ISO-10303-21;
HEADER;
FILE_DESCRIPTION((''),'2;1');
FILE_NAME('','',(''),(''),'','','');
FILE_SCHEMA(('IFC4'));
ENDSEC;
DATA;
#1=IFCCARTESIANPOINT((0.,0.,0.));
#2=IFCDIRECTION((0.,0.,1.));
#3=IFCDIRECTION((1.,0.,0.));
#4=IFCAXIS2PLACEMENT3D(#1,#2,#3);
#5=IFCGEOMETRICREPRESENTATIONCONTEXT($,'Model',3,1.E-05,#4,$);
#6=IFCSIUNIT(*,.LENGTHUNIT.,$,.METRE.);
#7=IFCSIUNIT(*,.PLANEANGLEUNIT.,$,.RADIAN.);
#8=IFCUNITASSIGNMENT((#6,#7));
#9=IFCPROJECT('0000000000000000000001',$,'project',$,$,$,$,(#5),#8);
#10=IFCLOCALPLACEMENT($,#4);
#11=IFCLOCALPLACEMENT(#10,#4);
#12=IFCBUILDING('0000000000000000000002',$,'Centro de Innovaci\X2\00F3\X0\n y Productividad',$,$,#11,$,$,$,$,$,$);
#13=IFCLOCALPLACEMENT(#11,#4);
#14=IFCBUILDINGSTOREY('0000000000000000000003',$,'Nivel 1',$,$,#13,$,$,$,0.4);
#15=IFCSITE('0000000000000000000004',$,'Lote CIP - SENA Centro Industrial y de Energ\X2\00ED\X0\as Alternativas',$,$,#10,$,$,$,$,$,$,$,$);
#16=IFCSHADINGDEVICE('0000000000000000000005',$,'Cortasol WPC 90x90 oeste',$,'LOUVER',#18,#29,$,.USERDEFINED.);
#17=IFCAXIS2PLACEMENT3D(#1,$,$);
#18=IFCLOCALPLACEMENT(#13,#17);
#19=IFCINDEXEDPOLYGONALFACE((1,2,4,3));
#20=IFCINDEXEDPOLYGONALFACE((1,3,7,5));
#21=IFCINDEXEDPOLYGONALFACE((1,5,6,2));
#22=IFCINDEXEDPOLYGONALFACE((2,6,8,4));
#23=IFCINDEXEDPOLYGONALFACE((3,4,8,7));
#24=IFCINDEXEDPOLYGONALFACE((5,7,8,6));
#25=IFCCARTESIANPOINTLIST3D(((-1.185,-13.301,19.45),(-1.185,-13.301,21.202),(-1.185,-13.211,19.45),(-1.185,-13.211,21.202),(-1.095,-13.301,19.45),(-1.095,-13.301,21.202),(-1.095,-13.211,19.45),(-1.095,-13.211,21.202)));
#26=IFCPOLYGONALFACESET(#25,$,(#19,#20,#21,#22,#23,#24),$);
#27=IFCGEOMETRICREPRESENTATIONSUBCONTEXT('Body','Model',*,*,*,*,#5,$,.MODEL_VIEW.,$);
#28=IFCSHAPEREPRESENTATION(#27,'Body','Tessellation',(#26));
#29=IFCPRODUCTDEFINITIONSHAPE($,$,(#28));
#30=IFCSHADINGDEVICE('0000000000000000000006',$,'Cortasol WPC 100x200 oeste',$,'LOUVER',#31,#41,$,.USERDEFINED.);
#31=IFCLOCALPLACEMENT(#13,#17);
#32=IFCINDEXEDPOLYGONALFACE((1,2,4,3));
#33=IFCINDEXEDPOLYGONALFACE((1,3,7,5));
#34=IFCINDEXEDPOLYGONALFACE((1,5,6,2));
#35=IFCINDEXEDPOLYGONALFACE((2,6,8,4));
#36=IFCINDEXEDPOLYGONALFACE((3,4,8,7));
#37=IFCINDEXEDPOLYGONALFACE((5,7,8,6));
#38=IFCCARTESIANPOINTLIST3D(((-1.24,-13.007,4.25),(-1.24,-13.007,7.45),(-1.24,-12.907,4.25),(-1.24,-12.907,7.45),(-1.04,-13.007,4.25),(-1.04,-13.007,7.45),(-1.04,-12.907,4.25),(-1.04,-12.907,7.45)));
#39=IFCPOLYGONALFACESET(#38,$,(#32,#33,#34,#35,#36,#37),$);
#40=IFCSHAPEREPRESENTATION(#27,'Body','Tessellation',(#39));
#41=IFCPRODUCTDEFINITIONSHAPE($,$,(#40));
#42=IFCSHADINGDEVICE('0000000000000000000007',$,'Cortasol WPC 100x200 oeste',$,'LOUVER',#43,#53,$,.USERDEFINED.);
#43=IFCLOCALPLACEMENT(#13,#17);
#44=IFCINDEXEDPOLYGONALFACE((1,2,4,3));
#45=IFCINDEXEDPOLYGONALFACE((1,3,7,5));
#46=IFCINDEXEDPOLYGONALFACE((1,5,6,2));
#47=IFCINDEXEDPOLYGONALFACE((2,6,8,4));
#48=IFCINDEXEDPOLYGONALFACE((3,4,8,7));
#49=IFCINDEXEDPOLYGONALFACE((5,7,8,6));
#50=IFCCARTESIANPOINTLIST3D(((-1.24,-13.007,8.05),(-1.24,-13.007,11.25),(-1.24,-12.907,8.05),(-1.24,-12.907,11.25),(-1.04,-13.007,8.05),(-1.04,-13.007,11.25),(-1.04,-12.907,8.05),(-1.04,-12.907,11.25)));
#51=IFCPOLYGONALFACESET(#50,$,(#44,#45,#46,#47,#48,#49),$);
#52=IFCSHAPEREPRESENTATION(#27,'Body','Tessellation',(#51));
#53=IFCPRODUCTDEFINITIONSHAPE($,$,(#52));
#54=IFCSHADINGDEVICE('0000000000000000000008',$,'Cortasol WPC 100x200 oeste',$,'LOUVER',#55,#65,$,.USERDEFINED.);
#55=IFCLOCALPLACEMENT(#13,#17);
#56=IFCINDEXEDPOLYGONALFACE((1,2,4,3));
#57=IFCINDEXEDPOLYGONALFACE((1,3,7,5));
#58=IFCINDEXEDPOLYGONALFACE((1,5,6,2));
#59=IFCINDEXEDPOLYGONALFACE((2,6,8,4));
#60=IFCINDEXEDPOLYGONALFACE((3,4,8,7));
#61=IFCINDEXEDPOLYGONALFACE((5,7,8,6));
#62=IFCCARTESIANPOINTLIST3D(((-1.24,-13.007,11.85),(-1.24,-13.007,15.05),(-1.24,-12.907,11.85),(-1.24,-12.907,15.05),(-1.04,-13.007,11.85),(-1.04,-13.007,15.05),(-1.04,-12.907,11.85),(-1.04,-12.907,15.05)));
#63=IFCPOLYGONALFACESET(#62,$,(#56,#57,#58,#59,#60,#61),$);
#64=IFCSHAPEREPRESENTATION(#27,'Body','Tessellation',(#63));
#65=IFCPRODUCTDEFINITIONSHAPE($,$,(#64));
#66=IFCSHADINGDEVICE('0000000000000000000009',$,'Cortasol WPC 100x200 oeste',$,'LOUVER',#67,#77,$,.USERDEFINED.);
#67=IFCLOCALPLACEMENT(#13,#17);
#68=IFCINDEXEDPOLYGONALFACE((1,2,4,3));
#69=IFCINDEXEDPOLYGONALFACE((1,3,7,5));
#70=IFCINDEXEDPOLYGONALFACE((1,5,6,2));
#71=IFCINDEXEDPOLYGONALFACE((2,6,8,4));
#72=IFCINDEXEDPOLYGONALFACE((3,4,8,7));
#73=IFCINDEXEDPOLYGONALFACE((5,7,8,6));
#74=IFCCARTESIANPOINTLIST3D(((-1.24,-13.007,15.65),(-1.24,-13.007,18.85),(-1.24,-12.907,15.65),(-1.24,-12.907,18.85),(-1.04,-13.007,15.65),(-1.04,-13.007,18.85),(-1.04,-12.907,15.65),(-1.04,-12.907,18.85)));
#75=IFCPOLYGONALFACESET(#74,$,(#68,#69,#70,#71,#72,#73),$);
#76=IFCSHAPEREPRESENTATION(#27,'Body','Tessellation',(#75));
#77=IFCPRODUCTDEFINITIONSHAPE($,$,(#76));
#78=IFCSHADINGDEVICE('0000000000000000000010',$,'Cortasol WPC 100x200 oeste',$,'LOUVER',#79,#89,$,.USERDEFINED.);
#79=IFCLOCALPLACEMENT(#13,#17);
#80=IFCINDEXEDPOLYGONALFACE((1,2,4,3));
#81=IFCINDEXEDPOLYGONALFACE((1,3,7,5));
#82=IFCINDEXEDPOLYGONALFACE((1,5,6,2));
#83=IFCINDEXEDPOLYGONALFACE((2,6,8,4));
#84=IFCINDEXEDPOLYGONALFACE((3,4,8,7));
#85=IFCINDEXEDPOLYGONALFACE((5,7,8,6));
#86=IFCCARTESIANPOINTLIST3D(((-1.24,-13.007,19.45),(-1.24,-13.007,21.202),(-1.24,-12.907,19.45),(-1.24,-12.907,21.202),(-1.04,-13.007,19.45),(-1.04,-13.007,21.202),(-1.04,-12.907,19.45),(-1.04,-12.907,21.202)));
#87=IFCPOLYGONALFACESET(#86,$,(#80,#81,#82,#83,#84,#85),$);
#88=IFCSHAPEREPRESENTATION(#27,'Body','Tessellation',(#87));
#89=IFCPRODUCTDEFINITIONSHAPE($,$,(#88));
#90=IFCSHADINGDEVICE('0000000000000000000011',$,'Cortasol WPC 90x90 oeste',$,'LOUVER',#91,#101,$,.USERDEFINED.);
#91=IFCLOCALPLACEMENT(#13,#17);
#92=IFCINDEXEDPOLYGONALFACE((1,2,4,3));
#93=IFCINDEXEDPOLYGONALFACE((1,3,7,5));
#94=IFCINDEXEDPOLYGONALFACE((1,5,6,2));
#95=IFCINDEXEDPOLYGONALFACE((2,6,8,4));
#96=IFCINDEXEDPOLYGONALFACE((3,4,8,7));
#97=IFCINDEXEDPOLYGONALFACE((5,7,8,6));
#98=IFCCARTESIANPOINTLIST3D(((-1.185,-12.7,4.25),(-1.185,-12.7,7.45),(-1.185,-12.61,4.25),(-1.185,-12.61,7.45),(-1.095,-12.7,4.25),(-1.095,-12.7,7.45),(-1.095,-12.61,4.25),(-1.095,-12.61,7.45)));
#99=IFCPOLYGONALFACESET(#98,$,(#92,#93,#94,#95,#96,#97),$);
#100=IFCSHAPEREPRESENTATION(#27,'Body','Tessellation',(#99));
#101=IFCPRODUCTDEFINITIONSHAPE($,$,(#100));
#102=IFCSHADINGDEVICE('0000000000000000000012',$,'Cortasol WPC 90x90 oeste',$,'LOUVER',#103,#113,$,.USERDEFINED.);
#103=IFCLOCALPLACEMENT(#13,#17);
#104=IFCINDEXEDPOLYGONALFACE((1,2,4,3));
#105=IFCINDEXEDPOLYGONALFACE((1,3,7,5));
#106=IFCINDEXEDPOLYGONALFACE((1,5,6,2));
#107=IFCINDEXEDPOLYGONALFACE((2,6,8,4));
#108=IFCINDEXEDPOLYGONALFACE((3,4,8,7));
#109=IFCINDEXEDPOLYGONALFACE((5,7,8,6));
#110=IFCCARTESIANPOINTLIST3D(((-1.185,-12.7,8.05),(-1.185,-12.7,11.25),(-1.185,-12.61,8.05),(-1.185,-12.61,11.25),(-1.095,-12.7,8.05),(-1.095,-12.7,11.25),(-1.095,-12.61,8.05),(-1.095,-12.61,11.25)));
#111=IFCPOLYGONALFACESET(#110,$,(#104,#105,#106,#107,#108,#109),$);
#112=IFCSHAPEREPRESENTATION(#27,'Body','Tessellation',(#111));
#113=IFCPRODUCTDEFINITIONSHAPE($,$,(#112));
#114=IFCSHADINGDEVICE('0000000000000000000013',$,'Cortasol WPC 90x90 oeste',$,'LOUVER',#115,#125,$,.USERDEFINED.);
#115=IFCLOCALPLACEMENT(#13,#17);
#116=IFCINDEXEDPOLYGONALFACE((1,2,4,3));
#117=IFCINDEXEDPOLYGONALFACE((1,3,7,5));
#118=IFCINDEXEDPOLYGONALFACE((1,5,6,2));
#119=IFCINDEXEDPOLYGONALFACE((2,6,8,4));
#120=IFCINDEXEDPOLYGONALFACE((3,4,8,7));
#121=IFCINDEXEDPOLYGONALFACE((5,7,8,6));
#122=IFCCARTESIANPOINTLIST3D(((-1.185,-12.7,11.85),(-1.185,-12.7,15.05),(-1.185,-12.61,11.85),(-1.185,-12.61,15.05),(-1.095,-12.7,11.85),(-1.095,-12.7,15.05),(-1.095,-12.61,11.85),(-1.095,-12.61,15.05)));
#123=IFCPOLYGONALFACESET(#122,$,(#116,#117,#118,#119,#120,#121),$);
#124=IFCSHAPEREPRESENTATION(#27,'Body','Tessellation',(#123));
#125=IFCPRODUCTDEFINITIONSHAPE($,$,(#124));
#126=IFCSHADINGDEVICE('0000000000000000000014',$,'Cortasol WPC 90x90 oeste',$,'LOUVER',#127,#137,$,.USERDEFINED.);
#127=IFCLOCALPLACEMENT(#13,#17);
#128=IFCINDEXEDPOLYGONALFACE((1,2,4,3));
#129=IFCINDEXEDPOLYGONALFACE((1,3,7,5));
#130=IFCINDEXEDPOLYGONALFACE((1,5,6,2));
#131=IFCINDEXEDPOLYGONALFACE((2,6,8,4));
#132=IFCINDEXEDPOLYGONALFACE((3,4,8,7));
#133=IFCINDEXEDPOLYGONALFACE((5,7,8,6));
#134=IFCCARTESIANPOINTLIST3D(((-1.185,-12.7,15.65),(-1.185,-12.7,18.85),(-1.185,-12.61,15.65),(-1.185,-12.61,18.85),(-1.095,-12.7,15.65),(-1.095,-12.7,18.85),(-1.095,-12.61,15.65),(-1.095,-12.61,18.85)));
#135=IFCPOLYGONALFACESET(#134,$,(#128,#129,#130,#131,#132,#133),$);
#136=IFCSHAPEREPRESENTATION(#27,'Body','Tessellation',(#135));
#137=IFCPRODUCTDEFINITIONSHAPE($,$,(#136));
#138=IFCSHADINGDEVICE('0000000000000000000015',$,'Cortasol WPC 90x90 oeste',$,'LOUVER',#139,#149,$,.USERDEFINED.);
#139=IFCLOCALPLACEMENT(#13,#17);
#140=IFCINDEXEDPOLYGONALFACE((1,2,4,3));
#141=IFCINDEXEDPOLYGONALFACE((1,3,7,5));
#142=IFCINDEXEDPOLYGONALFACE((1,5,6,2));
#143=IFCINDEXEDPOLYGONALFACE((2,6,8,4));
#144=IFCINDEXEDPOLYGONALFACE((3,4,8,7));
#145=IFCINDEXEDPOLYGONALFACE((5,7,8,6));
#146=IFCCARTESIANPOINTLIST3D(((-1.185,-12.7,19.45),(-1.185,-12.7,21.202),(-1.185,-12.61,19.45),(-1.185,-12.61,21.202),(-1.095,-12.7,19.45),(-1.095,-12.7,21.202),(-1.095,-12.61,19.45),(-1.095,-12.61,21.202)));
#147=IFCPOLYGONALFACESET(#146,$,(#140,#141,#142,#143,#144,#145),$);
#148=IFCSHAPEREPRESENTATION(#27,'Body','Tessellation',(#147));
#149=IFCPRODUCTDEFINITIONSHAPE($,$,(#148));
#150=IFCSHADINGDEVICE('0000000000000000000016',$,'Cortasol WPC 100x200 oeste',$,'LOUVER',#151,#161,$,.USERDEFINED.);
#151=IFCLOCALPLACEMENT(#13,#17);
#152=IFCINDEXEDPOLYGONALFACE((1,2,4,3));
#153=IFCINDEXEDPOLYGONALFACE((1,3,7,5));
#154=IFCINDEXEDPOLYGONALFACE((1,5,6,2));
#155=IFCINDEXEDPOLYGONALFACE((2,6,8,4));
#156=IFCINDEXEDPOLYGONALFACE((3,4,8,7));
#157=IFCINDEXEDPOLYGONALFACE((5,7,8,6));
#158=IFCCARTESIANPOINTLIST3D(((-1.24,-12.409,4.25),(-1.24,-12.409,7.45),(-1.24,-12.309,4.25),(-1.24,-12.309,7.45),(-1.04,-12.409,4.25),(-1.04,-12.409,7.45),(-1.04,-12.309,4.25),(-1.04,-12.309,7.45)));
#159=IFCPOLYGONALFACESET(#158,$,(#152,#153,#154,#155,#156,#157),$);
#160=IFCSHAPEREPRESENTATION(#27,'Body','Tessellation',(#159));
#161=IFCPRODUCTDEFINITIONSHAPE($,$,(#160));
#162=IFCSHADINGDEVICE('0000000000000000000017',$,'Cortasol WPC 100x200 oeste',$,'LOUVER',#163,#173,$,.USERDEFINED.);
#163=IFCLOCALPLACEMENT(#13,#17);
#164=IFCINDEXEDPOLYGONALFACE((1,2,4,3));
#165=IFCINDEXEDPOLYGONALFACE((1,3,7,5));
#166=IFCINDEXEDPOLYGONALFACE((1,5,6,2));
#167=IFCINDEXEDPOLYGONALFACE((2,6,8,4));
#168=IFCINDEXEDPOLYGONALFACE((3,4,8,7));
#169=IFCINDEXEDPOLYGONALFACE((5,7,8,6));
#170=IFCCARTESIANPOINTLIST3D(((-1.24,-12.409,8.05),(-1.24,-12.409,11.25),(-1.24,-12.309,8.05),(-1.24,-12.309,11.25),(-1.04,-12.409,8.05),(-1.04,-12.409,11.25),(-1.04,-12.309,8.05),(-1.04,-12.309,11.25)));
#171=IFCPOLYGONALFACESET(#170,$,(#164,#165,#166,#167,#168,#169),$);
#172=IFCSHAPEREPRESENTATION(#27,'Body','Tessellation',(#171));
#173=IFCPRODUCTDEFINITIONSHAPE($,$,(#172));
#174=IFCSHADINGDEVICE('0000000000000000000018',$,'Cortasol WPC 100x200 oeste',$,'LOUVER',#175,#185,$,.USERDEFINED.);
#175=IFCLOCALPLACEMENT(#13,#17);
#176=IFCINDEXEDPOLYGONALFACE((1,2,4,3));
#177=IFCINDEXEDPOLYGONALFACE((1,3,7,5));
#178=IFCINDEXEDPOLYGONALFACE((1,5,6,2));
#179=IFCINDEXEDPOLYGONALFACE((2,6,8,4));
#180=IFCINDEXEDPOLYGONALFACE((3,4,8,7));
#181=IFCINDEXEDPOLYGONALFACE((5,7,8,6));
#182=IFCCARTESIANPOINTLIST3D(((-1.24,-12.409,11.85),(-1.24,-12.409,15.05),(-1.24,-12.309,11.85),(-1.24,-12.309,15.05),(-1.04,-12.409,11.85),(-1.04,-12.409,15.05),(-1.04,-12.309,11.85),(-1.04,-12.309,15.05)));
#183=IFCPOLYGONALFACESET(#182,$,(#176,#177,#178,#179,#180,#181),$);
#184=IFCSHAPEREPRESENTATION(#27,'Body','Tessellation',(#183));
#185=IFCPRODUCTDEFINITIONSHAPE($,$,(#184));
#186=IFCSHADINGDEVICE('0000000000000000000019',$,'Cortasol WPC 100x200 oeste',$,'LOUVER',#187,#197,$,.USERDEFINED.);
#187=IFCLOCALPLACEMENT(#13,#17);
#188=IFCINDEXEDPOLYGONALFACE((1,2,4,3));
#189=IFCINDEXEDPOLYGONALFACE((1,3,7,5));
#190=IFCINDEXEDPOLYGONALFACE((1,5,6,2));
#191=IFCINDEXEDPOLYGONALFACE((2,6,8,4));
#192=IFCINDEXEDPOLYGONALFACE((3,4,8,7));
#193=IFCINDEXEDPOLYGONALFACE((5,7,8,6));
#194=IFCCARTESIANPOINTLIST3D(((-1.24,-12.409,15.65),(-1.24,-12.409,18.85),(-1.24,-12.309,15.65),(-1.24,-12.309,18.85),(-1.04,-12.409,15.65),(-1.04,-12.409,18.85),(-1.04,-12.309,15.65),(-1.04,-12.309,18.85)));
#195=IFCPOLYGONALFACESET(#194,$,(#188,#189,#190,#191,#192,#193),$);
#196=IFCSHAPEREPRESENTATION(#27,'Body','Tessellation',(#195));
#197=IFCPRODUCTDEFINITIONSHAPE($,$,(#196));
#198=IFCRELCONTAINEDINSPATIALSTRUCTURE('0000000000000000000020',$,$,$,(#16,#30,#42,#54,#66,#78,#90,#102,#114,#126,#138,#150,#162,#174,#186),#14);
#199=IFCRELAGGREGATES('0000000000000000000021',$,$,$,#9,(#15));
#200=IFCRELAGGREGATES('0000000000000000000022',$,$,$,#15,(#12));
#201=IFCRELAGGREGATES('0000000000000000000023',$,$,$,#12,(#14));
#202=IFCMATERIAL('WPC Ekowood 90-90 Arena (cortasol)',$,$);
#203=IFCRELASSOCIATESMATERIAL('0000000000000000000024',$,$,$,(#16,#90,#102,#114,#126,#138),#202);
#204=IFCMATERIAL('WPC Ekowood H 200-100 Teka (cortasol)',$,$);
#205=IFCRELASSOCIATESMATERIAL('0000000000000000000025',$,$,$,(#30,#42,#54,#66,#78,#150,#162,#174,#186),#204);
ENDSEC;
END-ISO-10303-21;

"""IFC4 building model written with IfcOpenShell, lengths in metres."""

from ifc_helpers import new_model, si_unit, frame, origin_with_axes, place, context, subcontext, project, spatial, polyline, outline, extrude, material, element, save


model = new_model("IFC4")

# Units and contexts
model_context = context("Model", 3, precision=1e-05, world=origin_with_axes())
body_context = subcontext(model_context, "Body", "Model", "MODEL_VIEW")
ifc_project = project(units=[si_unit("LENGTHUNIT", "METRE"), si_unit("PLANEANGLEUNIT", "RADIAN")], contexts=[model_context])

# Site, building, storey
site_placement = place(None, origin_with_axes())
site = spatial("IfcSite", under=ifc_project, at=site_placement, Name="Lote CIP - SENA Centro Industrial y de Energías Alternativas")
building_placement = place(site_placement, origin_with_axes())
building = spatial("IfcBuilding", under=site, at=building_placement, Name="Centro de Innovación y Productividad")
storey_placement = place(building_placement, origin_with_axes())
storey = spatial("IfcBuildingStorey", under=building, at=storey_placement, Name="Nivel 1", Elevation=0.4)

# Shading devices
ifc_material_1 = material(Name="WPC Ekowood 90-90 Arena (cortasol)")
shading_device_1_placement = place(storey_placement, origin_with_axes())
element("IfcShadingDevice", 1, at=shading_device_1_placement, inside=storey, material=ifc_material_1, Name="Cortasol WPC 90x90 oeste", ObjectType="LOUVER", PredefinedType="USERDEFINED", context=body_context, shape_type="SweptSolid", body=[
    extrude(outline(polyline([(-1.095, -13.301), (-1.185, -13.301), (-1.185, -13.211), (-1.095, -13.211), (-1.095, -13.301)])), frame((0.0, 0.0, 19.45)), (0.0, 0.0, 1.0), 1.752),
])
ifc_material_2 = material(Name="WPC Ekowood H 200-100 Teka (cortasol)")
shading_device_2_placement = place(storey_placement, origin_with_axes())
element("IfcShadingDevice", 2, at=shading_device_2_placement, inside=storey, material=ifc_material_2, Name="Cortasol WPC 100x200 oeste", ObjectType="LOUVER", PredefinedType="USERDEFINED", context=body_context, shape_type="SweptSolid", body=[
    extrude(outline(polyline([(-1.04, -13.007), (-1.24, -13.007), (-1.24, -12.907), (-1.04, -12.907), (-1.04, -13.007)])), frame((0.0, 0.0, 4.25)), (0.0, 0.0, 1.0), 3.2),
])
shading_device_3_placement = place(storey_placement, origin_with_axes())
element("IfcShadingDevice", 3, at=shading_device_3_placement, inside=storey, material=ifc_material_2, Name="Cortasol WPC 100x200 oeste", ObjectType="LOUVER", PredefinedType="USERDEFINED", context=body_context, shape_type="SweptSolid", body=[
    extrude(outline(polyline([(-1.04, -13.007), (-1.24, -13.007), (-1.24, -12.907), (-1.04, -12.907), (-1.04, -13.007)])), frame((0.0, 0.0, 8.05)), (0.0, 0.0, 1.0), 3.2),
])
shading_device_4_placement = place(storey_placement, origin_with_axes())
element("IfcShadingDevice", 4, at=shading_device_4_placement, inside=storey, material=ifc_material_2, Name="Cortasol WPC 100x200 oeste", ObjectType="LOUVER", PredefinedType="USERDEFINED", context=body_context, shape_type="SweptSolid", body=[
    extrude(outline(polyline([(-1.04, -13.007), (-1.24, -13.007), (-1.24, -12.907), (-1.04, -12.907), (-1.04, -13.007)])), frame((0.0, 0.0, 11.85)), (0.0, 0.0, 1.0), 3.2),
])
shading_device_5_placement = place(storey_placement, origin_with_axes())
element("IfcShadingDevice", 5, at=shading_device_5_placement, inside=storey, material=ifc_material_2, Name="Cortasol WPC 100x200 oeste", ObjectType="LOUVER", PredefinedType="USERDEFINED", context=body_context, shape_type="SweptSolid", body=[
    extrude(outline(polyline([(-1.04, -13.007), (-1.24, -13.007), (-1.24, -12.907), (-1.04, -12.907), (-1.04, -13.007)])), frame((0.0, 0.0, 15.65)), (0.0, 0.0, 1.0), 3.2),
])
shading_device_6_placement = place(storey_placement, origin_with_axes())
element("IfcShadingDevice", 6, at=shading_device_6_placement, inside=storey, material=ifc_material_2, Name="Cortasol WPC 100x200 oeste", ObjectType="LOUVER", PredefinedType="USERDEFINED", context=body_context, shape_type="SweptSolid", body=[
    extrude(outline(polyline([(-1.04, -13.007), (-1.24, -13.007), (-1.24, -12.907), (-1.04, -12.907), (-1.04, -13.007)])), frame((0.0, 0.0, 19.45)), (0.0, 0.0, 1.0), 1.752),
])
shading_device_7_placement = place(storey_placement, origin_with_axes())
element("IfcShadingDevice", 7, at=shading_device_7_placement, inside=storey, material=ifc_material_1, Name="Cortasol WPC 90x90 oeste", ObjectType="LOUVER", PredefinedType="USERDEFINED", context=body_context, shape_type="SweptSolid", body=[
    extrude(outline(polyline([(-1.095, -12.7), (-1.185, -12.7), (-1.185, -12.61), (-1.095, -12.61), (-1.095, -12.7)])), frame((0.0, 0.0, 4.25)), (0.0, 0.0, 1.0), 3.2),
])
shading_device_8_placement = place(storey_placement, origin_with_axes())
element("IfcShadingDevice", 8, at=shading_device_8_placement, inside=storey, material=ifc_material_1, Name="Cortasol WPC 90x90 oeste", ObjectType="LOUVER", PredefinedType="USERDEFINED", context=body_context, shape_type="SweptSolid", body=[
    extrude(outline(polyline([(-1.095, -12.7), (-1.185, -12.7), (-1.185, -12.61), (-1.095, -12.61), (-1.095, -12.7)])), frame((0.0, 0.0, 8.05)), (0.0, 0.0, 1.0), 3.2),
])
shading_device_9_placement = place(storey_placement, origin_with_axes())
element("IfcShadingDevice", 9, at=shading_device_9_placement, inside=storey, material=ifc_material_1, Name="Cortasol WPC 90x90 oeste", ObjectType="LOUVER", PredefinedType="USERDEFINED", context=body_context, shape_type="SweptSolid", body=[
    extrude(outline(polyline([(-1.095, -12.7), (-1.185, -12.7), (-1.185, -12.61), (-1.095, -12.61), (-1.095, -12.7)])), frame((0.0, 0.0, 11.85)), (0.0, 0.0, 1.0), 3.2),
])
shading_device_10_placement = place(storey_placement, origin_with_axes())
element("IfcShadingDevice", 10, at=shading_device_10_placement, inside=storey, material=ifc_material_1, Name="Cortasol WPC 90x90 oeste", ObjectType="LOUVER", PredefinedType="USERDEFINED", context=body_context, shape_type="SweptSolid", body=[
    extrude(outline(polyline([(-1.095, -12.7), (-1.185, -12.7), (-1.185, -12.61), (-1.095, -12.61), (-1.095, -12.7)])), frame((0.0, 0.0, 15.65)), (0.0, 0.0, 1.0), 3.2),
])
shading_device_11_placement = place(storey_placement, origin_with_axes())
element("IfcShadingDevice", 11, at=shading_device_11_placement, inside=storey, material=ifc_material_1, Name="Cortasol WPC 90x90 oeste", ObjectType="LOUVER", PredefinedType="USERDEFINED", context=body_context, shape_type="SweptSolid", body=[
    extrude(outline(polyline([(-1.095, -12.7), (-1.185, -12.7), (-1.185, -12.61), (-1.095, -12.61), (-1.095, -12.7)])), frame((0.0, 0.0, 19.45)), (0.0, 0.0, 1.0), 1.752),
])
shading_device_12_placement = place(storey_placement, origin_with_axes())
element("IfcShadingDevice", 12, at=shading_device_12_placement, inside=storey, material=ifc_material_2, Name="Cortasol WPC 100x200 oeste", ObjectType="LOUVER", PredefinedType="USERDEFINED", context=body_context, shape_type="SweptSolid", body=[
    extrude(outline(polyline([(-1.04, -12.409), (-1.24, -12.409), (-1.24, -12.309), (-1.04, -12.309), (-1.04, -12.409)])), frame((0.0, 0.0, 4.25)), (0.0, 0.0, 1.0), 3.2),
])
shading_device_13_placement = place(storey_placement, origin_with_axes())
element("IfcShadingDevice", 13, at=shading_device_13_placement, inside=storey, material=ifc_material_2, Name="Cortasol WPC 100x200 oeste", ObjectType="LOUVER", PredefinedType="USERDEFINED", context=body_context, shape_type="SweptSolid", body=[
    extrude(outline(polyline([(-1.04, -12.409), (-1.24, -12.409), (-1.24, -12.309), (-1.04, -12.309), (-1.04, -12.409)])), frame((0.0, 0.0, 8.05)), (0.0, 0.0, 1.0), 3.2),
])
shading_device_14_placement = place(storey_placement, origin_with_axes())
element("IfcShadingDevice", 14, at=shading_device_14_placement, inside=storey, material=ifc_material_2, Name="Cortasol WPC 100x200 oeste", ObjectType="LOUVER", PredefinedType="USERDEFINED", context=body_context, shape_type="SweptSolid", body=[
    extrude(outline(polyline([(-1.04, -12.409), (-1.24, -12.409), (-1.24, -12.309), (-1.04, -12.309), (-1.04, -12.409)])), frame((0.0, 0.0, 11.85)), (0.0, 0.0, 1.0), 3.2),
])
shading_device_15_placement = place(storey_placement, origin_with_axes())
element("IfcShadingDevice", 15, at=shading_device_15_placement, inside=storey, material=ifc_material_2, Name="Cortasol WPC 100x200 oeste", ObjectType="LOUVER", PredefinedType="USERDEFINED", context=body_context, shape_type="SweptSolid", body=[
    extrude(outline(polyline([(-1.04, -12.409), (-1.24, -12.409), (-1.24, -12.309), (-1.04, -12.309), (-1.04, -12.409)])), frame((0.0, 0.0, 15.65)), (0.0, 0.0, 1.0), 3.2),
])

save(model, "model.ifc")
